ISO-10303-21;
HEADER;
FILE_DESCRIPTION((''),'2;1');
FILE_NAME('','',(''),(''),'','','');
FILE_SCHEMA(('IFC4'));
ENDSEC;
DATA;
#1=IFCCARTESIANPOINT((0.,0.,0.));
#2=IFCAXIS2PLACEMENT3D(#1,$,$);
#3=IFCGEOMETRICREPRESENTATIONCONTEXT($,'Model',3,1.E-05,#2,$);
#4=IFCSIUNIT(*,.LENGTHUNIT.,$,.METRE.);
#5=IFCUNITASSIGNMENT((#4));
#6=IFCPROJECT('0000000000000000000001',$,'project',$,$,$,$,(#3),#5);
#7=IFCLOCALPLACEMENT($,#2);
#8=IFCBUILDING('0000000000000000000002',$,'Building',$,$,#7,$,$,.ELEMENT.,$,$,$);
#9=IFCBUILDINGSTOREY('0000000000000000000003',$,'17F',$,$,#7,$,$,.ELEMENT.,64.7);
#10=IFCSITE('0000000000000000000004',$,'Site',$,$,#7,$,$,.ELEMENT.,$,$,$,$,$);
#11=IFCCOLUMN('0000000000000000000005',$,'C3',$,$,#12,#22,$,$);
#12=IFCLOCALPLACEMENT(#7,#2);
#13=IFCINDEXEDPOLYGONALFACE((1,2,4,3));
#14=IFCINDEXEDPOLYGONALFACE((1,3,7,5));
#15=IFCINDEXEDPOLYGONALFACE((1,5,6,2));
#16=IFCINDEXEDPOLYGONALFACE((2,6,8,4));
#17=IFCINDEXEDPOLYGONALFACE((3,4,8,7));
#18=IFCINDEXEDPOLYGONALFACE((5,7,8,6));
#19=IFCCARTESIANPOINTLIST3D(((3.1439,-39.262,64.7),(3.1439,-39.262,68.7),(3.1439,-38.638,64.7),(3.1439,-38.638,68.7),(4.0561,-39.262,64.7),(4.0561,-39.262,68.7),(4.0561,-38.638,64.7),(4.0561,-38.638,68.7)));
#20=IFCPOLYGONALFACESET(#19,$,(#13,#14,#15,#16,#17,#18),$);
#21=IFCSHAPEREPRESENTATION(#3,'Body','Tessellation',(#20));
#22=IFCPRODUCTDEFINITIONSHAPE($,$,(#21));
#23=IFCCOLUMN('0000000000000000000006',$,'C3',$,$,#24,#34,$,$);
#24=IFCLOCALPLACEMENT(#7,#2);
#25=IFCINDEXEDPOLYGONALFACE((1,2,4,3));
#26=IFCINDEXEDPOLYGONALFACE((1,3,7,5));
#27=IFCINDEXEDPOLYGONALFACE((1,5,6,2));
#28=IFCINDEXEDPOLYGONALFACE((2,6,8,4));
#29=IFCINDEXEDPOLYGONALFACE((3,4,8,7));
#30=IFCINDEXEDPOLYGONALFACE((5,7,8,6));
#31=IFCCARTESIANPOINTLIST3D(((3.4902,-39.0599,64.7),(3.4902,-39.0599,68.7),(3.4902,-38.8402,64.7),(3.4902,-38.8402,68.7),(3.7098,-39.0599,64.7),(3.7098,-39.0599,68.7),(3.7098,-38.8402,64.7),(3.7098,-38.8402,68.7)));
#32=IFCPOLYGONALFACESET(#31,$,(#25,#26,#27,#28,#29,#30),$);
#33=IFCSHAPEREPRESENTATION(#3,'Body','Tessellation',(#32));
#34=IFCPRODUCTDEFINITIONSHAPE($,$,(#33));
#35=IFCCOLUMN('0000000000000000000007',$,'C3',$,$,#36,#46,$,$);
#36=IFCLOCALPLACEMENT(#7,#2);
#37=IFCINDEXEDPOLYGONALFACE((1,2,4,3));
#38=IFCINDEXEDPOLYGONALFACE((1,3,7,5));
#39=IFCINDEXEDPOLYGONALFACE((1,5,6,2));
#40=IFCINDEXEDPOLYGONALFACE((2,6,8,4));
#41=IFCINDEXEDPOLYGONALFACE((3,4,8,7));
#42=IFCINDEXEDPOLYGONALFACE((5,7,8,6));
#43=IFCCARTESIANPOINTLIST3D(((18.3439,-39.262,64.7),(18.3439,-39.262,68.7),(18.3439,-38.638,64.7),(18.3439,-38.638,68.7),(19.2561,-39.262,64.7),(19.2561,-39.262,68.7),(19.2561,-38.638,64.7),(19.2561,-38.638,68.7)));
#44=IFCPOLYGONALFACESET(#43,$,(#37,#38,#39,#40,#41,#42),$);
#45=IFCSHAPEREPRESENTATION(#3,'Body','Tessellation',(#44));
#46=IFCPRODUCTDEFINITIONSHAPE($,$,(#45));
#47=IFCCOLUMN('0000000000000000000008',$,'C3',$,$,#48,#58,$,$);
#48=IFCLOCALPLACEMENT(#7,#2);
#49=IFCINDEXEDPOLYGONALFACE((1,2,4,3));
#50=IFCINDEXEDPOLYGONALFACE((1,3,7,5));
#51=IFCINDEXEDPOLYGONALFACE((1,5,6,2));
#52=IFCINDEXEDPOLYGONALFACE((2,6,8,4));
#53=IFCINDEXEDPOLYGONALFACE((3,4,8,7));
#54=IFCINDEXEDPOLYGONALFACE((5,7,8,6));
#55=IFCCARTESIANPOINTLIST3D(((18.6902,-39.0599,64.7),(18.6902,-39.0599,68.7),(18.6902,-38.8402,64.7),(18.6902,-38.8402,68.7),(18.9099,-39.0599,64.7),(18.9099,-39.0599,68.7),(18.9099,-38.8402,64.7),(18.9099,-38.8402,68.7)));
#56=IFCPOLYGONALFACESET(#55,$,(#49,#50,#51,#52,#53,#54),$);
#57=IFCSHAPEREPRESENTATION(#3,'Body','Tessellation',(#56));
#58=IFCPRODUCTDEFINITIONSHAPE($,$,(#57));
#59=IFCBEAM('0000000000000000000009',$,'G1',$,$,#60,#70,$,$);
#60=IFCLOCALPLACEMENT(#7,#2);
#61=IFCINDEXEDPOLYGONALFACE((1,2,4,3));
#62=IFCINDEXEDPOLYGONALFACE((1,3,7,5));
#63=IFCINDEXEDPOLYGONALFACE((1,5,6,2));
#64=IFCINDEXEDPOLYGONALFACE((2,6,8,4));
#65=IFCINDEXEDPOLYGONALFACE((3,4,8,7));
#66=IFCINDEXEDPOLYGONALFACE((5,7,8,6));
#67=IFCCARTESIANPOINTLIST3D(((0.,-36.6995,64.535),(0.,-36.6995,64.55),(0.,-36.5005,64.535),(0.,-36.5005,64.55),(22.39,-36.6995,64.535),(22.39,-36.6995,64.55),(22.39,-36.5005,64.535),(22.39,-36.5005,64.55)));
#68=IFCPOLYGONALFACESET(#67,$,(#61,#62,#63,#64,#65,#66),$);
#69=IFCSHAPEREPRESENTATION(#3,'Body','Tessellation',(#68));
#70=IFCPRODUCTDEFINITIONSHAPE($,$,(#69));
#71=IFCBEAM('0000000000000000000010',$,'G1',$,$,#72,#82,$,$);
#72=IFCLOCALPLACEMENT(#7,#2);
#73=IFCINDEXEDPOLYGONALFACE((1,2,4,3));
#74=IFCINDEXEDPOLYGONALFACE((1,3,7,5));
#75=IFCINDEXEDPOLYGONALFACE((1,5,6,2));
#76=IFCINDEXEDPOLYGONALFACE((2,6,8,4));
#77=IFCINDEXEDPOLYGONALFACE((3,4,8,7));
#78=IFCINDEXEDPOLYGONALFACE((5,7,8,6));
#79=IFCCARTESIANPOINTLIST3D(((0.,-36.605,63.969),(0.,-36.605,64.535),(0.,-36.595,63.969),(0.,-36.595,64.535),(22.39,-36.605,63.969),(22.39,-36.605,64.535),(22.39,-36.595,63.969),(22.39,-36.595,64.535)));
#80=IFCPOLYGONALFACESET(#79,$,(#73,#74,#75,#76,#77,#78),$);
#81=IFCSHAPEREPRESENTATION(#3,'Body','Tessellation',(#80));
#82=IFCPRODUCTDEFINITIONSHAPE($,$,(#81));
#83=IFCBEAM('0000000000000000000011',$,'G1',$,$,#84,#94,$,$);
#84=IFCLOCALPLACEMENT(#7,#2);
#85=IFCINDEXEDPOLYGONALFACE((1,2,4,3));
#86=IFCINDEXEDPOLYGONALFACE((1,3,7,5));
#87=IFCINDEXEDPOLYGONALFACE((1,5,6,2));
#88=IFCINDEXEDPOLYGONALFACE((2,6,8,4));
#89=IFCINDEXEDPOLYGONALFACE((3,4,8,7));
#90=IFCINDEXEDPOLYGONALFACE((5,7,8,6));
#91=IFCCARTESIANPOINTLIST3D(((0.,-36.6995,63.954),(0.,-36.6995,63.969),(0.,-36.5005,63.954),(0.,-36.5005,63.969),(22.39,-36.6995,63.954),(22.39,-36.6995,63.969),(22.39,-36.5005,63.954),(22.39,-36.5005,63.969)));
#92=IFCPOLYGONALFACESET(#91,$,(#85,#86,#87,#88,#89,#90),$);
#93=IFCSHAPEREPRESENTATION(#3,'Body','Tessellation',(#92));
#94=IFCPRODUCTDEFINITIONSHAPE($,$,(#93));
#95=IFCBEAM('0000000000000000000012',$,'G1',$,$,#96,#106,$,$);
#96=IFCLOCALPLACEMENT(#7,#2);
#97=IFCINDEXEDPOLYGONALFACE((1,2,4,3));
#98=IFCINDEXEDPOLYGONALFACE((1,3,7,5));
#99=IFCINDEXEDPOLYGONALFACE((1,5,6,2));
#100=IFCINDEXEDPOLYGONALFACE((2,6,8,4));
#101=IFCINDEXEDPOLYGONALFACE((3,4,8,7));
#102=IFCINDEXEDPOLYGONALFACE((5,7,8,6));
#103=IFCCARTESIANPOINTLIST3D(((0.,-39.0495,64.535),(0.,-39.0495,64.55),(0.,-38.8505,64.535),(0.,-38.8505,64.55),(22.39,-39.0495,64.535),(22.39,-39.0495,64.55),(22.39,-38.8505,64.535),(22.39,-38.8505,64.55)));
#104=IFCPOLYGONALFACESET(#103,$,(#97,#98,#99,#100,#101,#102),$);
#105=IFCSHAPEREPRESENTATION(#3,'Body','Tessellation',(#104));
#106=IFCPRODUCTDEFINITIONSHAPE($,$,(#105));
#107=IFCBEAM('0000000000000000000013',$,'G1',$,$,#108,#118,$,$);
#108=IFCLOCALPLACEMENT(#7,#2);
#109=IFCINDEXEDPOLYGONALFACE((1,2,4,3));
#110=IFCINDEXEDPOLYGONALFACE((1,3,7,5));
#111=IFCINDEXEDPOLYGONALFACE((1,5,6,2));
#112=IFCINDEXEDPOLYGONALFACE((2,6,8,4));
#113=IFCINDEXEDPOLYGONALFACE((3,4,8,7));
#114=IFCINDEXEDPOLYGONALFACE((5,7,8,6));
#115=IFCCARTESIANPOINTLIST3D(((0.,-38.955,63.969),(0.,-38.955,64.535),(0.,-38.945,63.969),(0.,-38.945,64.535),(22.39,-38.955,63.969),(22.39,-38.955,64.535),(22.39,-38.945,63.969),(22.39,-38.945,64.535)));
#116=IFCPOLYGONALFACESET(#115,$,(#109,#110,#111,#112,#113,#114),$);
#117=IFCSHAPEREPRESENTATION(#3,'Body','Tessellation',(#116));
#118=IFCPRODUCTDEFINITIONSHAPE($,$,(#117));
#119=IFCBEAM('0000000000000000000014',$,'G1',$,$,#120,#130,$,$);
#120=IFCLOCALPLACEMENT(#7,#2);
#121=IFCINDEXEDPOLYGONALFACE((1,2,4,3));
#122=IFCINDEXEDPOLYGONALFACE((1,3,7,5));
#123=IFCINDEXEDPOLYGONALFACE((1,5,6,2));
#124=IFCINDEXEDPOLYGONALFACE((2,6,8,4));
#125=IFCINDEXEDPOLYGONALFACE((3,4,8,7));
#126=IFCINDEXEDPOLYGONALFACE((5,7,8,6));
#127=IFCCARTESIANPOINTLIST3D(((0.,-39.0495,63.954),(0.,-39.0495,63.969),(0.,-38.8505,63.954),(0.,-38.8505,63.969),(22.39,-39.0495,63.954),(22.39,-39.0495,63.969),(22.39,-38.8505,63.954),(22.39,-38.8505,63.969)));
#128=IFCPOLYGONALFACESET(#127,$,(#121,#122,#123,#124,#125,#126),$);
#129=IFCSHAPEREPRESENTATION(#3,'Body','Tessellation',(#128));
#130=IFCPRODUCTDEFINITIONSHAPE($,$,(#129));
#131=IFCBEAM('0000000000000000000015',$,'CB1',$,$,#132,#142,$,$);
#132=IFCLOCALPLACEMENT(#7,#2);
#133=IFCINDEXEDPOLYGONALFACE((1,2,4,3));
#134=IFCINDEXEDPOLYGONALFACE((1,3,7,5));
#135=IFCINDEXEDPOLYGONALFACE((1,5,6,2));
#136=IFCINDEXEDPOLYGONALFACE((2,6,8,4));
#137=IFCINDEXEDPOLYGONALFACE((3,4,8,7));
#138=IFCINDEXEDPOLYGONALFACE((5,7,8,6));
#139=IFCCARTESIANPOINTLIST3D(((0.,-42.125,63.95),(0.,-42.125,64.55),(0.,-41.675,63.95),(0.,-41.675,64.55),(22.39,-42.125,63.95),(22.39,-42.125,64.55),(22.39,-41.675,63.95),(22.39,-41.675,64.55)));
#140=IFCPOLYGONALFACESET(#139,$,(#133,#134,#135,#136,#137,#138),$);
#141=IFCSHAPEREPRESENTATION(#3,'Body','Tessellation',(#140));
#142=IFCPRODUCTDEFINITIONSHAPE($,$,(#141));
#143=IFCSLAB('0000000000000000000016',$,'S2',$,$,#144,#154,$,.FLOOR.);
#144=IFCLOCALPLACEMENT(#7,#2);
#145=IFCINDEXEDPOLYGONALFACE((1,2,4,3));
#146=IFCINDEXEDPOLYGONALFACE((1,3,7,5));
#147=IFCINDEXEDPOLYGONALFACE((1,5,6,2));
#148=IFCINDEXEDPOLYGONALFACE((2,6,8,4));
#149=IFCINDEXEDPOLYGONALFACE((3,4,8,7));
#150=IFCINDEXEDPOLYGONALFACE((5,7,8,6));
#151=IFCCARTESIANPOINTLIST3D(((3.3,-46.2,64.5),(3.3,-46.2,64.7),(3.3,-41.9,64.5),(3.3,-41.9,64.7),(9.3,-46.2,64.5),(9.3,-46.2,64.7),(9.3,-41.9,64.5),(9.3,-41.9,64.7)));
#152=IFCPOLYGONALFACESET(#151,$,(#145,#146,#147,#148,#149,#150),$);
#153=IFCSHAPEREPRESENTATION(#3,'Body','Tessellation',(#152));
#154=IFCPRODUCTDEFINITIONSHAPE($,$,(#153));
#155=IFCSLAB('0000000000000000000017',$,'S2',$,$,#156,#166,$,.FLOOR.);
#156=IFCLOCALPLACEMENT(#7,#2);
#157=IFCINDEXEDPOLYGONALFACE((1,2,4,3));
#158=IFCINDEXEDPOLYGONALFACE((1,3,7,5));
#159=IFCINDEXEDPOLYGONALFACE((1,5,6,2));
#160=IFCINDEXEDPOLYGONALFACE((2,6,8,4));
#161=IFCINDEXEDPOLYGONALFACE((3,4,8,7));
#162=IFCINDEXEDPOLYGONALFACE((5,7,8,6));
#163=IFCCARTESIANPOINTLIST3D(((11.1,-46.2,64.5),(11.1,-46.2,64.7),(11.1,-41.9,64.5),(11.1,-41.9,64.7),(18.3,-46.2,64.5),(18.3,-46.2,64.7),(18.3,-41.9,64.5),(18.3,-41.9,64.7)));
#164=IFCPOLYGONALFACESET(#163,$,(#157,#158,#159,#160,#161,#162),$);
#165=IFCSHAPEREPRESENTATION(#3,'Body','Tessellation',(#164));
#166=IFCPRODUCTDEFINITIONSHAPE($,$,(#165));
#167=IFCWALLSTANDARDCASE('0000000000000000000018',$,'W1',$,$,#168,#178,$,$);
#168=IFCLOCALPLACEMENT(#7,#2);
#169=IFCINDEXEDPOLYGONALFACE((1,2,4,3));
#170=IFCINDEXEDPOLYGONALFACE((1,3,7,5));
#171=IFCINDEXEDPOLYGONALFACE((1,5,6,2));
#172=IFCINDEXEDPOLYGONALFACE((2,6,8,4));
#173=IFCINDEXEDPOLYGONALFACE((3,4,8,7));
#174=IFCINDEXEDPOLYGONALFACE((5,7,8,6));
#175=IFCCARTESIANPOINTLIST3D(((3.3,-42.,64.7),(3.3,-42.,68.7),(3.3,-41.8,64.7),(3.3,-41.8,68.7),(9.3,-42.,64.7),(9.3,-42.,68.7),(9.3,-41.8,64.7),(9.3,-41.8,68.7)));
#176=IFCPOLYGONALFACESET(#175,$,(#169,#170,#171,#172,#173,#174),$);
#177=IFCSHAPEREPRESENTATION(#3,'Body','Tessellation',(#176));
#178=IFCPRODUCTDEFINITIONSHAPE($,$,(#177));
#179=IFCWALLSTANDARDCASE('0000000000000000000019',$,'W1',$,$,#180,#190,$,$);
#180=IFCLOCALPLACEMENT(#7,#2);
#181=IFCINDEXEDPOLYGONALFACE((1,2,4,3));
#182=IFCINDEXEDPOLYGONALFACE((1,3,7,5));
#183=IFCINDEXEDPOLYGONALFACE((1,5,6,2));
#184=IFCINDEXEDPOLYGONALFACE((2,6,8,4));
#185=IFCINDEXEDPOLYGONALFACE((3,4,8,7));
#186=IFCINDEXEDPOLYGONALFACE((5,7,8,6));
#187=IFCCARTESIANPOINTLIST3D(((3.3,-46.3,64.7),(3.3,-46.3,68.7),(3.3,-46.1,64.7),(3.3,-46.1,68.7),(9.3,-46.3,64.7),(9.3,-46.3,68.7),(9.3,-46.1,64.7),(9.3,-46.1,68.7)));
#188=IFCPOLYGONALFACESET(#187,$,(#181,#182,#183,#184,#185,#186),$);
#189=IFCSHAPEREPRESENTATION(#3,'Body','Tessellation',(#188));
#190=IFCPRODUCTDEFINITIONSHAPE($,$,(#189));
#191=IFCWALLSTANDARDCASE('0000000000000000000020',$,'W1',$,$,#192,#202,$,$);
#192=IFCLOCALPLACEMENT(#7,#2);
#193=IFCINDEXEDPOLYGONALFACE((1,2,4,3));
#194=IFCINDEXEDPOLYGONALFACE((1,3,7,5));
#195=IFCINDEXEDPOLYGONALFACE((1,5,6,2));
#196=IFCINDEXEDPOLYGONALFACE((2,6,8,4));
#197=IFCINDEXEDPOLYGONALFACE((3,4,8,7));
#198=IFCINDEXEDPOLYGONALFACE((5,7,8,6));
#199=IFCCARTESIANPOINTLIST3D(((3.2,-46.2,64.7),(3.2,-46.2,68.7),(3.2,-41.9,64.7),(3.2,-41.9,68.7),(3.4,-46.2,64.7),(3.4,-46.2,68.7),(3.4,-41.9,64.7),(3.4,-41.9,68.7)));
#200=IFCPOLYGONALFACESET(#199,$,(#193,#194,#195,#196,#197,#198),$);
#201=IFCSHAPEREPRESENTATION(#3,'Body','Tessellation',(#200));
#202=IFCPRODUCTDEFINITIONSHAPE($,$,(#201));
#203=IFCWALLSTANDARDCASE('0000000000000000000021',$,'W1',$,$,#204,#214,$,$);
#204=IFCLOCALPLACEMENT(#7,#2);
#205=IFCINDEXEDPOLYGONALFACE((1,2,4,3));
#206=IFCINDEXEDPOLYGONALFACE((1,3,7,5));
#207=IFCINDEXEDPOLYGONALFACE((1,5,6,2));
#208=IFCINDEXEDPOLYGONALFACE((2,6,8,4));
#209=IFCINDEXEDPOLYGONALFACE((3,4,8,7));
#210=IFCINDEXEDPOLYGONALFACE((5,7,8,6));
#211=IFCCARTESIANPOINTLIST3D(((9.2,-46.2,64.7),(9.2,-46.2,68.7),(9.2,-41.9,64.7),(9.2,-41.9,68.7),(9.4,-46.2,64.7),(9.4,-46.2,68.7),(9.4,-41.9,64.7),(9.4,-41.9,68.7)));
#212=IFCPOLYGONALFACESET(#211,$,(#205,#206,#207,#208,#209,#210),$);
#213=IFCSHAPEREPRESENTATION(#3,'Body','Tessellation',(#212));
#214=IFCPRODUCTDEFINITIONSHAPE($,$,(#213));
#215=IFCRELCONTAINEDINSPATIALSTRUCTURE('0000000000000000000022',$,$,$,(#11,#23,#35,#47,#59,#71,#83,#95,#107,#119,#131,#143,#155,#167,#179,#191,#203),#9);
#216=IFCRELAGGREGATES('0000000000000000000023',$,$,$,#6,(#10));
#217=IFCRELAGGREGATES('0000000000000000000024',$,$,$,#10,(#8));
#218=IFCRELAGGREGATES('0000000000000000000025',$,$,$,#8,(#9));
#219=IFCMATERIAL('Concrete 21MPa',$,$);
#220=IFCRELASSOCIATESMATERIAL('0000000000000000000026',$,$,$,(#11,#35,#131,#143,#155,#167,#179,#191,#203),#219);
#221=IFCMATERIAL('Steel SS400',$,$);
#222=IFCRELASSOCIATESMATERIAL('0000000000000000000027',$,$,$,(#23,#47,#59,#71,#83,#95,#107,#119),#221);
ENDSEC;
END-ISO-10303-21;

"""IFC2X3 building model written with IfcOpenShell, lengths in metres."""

from ifc_helpers import new_model, si_unit, frame, origin, origin_2d, place, context, project, spatial, rectangle, extrude, material, element, save


model = new_model("IFC2X3")

# Units and contexts
model_context = context("Model", 3, precision=1e-05, world=origin())
ifc_project = project(units=[si_unit("LENGTHUNIT", "METRE")], contexts=[model_context])

# Site, building, storey
placement = place(None, origin())
site = spatial("IfcSite", under=ifc_project, at=placement, Name="Site", CompositionType="ELEMENT")
building = spatial("IfcBuilding", under=site, at=placement, Name="Building", CompositionType="ELEMENT")
storey = spatial("IfcBuildingStorey", under=building, at=placement, Name="17F", CompositionType="ELEMENT", Elevation=64.7)

# Columns
ifc_material_1 = material(Name="Concrete 21MPa")
column_1_placement = place(None, frame((3.6, -38.95, 64.7)))
element("IfcColumn", 1, at=column_1_placement, inside=storey, material=ifc_material_1, Name="C3", context=model_context, shape_type="SweptSolid", body=[
    extrude(rectangle(XDim=0.9121, YDim=0.6241, at=origin_2d()), origin(), (0.0, 0.0, 1.0), 4.0),
])
ifc_material_2 = material(Name="Steel SS400")
column_2_placement = place(None, frame((3.6, -38.95, 64.7)))
element("IfcColumn", 2, at=column_2_placement, inside=storey, material=ifc_material_2, Name="C3", context=model_context, shape_type="SweptSolid", body=[
    extrude(rectangle(XDim=0.2197, YDim=0.2197, at=origin_2d()), origin(), (0.0, 0.0, 1.0), 4.0),
])
column_3_placement = place(None, frame((18.8, -38.95, 64.7)))
element("IfcColumn", 3, at=column_3_placement, inside=storey, material=ifc_material_1, Name="C3", context=model_context, shape_type="SweptSolid", body=[
    extrude(rectangle(XDim=0.9121, YDim=0.6241, at=origin_2d()), origin(), (0.0, 0.0, 1.0), 4.0),
])
column_4_placement = place(None, frame((18.8, -38.95, 64.7)))
element("IfcColumn", 4, at=column_4_placement, inside=storey, material=ifc_material_2, Name="C3", context=model_context, shape_type="SweptSolid", body=[
    extrude(rectangle(XDim=0.2197, YDim=0.2197, at=origin_2d()), origin(), (0.0, 0.0, 1.0), 4.0),
])

# Beams
beam_1_placement = place(None, frame((11.195, -36.6, 64.535)))
element("IfcBeam", 5, at=beam_1_placement, inside=storey, material=ifc_material_2, Name="G1", context=model_context, shape_type="SweptSolid", body=[
    extrude(rectangle(XDim=22.39, YDim=0.199, at=origin_2d()), origin(), (0.0, 0.0, 1.0), 0.015),
])
beam_2_placement = place(None, frame((11.195, -36.6, 63.969)))
element("IfcBeam", 6, at=beam_2_placement, inside=storey, material=ifc_material_2, Name="G1", context=model_context, shape_type="SweptSolid", body=[
    extrude(rectangle(XDim=22.39, YDim=0.01, at=origin_2d()), origin(), (0.0, 0.0, 1.0), 0.566),
])
for number, where, name in (
    (7, (11.195, -36.6, 63.954), "G1"),
    (8, (11.195, -38.95, 64.535), "G1"),
):
    element("IfcBeam", number, at=place(None, frame(where)), inside=storey, material=ifc_material_2, Name=name, context=model_context, shape_type="SweptSolid", body=[
        extrude(rectangle(XDim=22.39, YDim=0.199, at=origin_2d()), origin(), (0.0, 0.0, 1.0), 0.015),
    ])
beam_3_placement = place(None, frame((11.195, -38.95, 63.969)))
element("IfcBeam", 9, at=beam_3_placement, inside=storey, material=ifc_material_2, Name="G1", context=model_context, shape_type="SweptSolid", body=[
    extrude(rectangle(XDim=22.39, YDim=0.01, at=origin_2d()), origin(), (0.0, 0.0, 1.0), 0.566),
])
beam_4_placement = place(None, frame((11.195, -38.95, 63.954)))
element("IfcBeam", 10, at=beam_4_placement, inside=storey, material=ifc_material_2, Name="G1", context=model_context, shape_type="SweptSolid", body=[
    extrude(rectangle(XDim=22.39, YDim=0.199, at=origin_2d()), origin(), (0.0, 0.0, 1.0), 0.015),
])
beam_5_placement = place(None, frame((11.195, -41.9, 63.95)))
element("IfcBeam", 11, at=beam_5_placement, inside=storey, material=ifc_material_1, Name="CB1", context=model_context, shape_type="SweptSolid", body=[
    extrude(rectangle(XDim=22.39, YDim=0.45, at=origin_2d()), origin(), (0.0, 0.0, 1.0), 0.6),
])

# Slabs
slab_1_placement = place(None, frame((6.3, -44.05, 64.5)))
element("IfcSlab", 12, at=slab_1_placement, inside=storey, material=ifc_material_1, Name="S2", PredefinedType="FLOOR", context=model_context, shape_type="SweptSolid", body=[
    extrude(rectangle(XDim=6.0, YDim=4.3, at=origin_2d()), origin(), (0.0, 0.0, 1.0), 0.2),
])
slab_2_placement = place(None, frame((14.7, -44.05, 64.5)))
element("IfcSlab", 13, at=slab_2_placement, inside=storey, material=ifc_material_1, Name="S2", PredefinedType="FLOOR", context=model_context, shape_type="SweptSolid", body=[
    extrude(rectangle(XDim=7.2, YDim=4.3, at=origin_2d()), origin(), (0.0, 0.0, 1.0), 0.2),
])

# Walls
for number, where, name in (
    (14, (6.3, -41.9, 64.7), "W1"),
    (15, (6.3, -46.2, 64.7), "W1"),
):
    element("IfcWallStandardCase", number, at=place(None, frame(where)), inside=storey, material=ifc_material_1, Name=name, context=model_context, shape_type="SweptSolid", body=[
        extrude(rectangle(XDim=6.0, YDim=0.2, at=origin_2d()), origin(), (0.0, 0.0, 1.0), 4.0),
    ])
for number, where, name in (
    (16, (3.3, -44.05, 64.7), "W1"),
    (17, (9.3, -44.05, 64.7), "W1"),
):
    element("IfcWallStandardCase", number, at=place(None, frame(where)), inside=storey, material=ifc_material_1, Name=name, context=model_context, shape_type="SweptSolid", body=[
        extrude(rectangle(XDim=0.2, YDim=4.3, at=origin_2d()), origin(), (0.0, 0.0, 1.0), 4.0),
    ])

save(model, "model.ifc")
